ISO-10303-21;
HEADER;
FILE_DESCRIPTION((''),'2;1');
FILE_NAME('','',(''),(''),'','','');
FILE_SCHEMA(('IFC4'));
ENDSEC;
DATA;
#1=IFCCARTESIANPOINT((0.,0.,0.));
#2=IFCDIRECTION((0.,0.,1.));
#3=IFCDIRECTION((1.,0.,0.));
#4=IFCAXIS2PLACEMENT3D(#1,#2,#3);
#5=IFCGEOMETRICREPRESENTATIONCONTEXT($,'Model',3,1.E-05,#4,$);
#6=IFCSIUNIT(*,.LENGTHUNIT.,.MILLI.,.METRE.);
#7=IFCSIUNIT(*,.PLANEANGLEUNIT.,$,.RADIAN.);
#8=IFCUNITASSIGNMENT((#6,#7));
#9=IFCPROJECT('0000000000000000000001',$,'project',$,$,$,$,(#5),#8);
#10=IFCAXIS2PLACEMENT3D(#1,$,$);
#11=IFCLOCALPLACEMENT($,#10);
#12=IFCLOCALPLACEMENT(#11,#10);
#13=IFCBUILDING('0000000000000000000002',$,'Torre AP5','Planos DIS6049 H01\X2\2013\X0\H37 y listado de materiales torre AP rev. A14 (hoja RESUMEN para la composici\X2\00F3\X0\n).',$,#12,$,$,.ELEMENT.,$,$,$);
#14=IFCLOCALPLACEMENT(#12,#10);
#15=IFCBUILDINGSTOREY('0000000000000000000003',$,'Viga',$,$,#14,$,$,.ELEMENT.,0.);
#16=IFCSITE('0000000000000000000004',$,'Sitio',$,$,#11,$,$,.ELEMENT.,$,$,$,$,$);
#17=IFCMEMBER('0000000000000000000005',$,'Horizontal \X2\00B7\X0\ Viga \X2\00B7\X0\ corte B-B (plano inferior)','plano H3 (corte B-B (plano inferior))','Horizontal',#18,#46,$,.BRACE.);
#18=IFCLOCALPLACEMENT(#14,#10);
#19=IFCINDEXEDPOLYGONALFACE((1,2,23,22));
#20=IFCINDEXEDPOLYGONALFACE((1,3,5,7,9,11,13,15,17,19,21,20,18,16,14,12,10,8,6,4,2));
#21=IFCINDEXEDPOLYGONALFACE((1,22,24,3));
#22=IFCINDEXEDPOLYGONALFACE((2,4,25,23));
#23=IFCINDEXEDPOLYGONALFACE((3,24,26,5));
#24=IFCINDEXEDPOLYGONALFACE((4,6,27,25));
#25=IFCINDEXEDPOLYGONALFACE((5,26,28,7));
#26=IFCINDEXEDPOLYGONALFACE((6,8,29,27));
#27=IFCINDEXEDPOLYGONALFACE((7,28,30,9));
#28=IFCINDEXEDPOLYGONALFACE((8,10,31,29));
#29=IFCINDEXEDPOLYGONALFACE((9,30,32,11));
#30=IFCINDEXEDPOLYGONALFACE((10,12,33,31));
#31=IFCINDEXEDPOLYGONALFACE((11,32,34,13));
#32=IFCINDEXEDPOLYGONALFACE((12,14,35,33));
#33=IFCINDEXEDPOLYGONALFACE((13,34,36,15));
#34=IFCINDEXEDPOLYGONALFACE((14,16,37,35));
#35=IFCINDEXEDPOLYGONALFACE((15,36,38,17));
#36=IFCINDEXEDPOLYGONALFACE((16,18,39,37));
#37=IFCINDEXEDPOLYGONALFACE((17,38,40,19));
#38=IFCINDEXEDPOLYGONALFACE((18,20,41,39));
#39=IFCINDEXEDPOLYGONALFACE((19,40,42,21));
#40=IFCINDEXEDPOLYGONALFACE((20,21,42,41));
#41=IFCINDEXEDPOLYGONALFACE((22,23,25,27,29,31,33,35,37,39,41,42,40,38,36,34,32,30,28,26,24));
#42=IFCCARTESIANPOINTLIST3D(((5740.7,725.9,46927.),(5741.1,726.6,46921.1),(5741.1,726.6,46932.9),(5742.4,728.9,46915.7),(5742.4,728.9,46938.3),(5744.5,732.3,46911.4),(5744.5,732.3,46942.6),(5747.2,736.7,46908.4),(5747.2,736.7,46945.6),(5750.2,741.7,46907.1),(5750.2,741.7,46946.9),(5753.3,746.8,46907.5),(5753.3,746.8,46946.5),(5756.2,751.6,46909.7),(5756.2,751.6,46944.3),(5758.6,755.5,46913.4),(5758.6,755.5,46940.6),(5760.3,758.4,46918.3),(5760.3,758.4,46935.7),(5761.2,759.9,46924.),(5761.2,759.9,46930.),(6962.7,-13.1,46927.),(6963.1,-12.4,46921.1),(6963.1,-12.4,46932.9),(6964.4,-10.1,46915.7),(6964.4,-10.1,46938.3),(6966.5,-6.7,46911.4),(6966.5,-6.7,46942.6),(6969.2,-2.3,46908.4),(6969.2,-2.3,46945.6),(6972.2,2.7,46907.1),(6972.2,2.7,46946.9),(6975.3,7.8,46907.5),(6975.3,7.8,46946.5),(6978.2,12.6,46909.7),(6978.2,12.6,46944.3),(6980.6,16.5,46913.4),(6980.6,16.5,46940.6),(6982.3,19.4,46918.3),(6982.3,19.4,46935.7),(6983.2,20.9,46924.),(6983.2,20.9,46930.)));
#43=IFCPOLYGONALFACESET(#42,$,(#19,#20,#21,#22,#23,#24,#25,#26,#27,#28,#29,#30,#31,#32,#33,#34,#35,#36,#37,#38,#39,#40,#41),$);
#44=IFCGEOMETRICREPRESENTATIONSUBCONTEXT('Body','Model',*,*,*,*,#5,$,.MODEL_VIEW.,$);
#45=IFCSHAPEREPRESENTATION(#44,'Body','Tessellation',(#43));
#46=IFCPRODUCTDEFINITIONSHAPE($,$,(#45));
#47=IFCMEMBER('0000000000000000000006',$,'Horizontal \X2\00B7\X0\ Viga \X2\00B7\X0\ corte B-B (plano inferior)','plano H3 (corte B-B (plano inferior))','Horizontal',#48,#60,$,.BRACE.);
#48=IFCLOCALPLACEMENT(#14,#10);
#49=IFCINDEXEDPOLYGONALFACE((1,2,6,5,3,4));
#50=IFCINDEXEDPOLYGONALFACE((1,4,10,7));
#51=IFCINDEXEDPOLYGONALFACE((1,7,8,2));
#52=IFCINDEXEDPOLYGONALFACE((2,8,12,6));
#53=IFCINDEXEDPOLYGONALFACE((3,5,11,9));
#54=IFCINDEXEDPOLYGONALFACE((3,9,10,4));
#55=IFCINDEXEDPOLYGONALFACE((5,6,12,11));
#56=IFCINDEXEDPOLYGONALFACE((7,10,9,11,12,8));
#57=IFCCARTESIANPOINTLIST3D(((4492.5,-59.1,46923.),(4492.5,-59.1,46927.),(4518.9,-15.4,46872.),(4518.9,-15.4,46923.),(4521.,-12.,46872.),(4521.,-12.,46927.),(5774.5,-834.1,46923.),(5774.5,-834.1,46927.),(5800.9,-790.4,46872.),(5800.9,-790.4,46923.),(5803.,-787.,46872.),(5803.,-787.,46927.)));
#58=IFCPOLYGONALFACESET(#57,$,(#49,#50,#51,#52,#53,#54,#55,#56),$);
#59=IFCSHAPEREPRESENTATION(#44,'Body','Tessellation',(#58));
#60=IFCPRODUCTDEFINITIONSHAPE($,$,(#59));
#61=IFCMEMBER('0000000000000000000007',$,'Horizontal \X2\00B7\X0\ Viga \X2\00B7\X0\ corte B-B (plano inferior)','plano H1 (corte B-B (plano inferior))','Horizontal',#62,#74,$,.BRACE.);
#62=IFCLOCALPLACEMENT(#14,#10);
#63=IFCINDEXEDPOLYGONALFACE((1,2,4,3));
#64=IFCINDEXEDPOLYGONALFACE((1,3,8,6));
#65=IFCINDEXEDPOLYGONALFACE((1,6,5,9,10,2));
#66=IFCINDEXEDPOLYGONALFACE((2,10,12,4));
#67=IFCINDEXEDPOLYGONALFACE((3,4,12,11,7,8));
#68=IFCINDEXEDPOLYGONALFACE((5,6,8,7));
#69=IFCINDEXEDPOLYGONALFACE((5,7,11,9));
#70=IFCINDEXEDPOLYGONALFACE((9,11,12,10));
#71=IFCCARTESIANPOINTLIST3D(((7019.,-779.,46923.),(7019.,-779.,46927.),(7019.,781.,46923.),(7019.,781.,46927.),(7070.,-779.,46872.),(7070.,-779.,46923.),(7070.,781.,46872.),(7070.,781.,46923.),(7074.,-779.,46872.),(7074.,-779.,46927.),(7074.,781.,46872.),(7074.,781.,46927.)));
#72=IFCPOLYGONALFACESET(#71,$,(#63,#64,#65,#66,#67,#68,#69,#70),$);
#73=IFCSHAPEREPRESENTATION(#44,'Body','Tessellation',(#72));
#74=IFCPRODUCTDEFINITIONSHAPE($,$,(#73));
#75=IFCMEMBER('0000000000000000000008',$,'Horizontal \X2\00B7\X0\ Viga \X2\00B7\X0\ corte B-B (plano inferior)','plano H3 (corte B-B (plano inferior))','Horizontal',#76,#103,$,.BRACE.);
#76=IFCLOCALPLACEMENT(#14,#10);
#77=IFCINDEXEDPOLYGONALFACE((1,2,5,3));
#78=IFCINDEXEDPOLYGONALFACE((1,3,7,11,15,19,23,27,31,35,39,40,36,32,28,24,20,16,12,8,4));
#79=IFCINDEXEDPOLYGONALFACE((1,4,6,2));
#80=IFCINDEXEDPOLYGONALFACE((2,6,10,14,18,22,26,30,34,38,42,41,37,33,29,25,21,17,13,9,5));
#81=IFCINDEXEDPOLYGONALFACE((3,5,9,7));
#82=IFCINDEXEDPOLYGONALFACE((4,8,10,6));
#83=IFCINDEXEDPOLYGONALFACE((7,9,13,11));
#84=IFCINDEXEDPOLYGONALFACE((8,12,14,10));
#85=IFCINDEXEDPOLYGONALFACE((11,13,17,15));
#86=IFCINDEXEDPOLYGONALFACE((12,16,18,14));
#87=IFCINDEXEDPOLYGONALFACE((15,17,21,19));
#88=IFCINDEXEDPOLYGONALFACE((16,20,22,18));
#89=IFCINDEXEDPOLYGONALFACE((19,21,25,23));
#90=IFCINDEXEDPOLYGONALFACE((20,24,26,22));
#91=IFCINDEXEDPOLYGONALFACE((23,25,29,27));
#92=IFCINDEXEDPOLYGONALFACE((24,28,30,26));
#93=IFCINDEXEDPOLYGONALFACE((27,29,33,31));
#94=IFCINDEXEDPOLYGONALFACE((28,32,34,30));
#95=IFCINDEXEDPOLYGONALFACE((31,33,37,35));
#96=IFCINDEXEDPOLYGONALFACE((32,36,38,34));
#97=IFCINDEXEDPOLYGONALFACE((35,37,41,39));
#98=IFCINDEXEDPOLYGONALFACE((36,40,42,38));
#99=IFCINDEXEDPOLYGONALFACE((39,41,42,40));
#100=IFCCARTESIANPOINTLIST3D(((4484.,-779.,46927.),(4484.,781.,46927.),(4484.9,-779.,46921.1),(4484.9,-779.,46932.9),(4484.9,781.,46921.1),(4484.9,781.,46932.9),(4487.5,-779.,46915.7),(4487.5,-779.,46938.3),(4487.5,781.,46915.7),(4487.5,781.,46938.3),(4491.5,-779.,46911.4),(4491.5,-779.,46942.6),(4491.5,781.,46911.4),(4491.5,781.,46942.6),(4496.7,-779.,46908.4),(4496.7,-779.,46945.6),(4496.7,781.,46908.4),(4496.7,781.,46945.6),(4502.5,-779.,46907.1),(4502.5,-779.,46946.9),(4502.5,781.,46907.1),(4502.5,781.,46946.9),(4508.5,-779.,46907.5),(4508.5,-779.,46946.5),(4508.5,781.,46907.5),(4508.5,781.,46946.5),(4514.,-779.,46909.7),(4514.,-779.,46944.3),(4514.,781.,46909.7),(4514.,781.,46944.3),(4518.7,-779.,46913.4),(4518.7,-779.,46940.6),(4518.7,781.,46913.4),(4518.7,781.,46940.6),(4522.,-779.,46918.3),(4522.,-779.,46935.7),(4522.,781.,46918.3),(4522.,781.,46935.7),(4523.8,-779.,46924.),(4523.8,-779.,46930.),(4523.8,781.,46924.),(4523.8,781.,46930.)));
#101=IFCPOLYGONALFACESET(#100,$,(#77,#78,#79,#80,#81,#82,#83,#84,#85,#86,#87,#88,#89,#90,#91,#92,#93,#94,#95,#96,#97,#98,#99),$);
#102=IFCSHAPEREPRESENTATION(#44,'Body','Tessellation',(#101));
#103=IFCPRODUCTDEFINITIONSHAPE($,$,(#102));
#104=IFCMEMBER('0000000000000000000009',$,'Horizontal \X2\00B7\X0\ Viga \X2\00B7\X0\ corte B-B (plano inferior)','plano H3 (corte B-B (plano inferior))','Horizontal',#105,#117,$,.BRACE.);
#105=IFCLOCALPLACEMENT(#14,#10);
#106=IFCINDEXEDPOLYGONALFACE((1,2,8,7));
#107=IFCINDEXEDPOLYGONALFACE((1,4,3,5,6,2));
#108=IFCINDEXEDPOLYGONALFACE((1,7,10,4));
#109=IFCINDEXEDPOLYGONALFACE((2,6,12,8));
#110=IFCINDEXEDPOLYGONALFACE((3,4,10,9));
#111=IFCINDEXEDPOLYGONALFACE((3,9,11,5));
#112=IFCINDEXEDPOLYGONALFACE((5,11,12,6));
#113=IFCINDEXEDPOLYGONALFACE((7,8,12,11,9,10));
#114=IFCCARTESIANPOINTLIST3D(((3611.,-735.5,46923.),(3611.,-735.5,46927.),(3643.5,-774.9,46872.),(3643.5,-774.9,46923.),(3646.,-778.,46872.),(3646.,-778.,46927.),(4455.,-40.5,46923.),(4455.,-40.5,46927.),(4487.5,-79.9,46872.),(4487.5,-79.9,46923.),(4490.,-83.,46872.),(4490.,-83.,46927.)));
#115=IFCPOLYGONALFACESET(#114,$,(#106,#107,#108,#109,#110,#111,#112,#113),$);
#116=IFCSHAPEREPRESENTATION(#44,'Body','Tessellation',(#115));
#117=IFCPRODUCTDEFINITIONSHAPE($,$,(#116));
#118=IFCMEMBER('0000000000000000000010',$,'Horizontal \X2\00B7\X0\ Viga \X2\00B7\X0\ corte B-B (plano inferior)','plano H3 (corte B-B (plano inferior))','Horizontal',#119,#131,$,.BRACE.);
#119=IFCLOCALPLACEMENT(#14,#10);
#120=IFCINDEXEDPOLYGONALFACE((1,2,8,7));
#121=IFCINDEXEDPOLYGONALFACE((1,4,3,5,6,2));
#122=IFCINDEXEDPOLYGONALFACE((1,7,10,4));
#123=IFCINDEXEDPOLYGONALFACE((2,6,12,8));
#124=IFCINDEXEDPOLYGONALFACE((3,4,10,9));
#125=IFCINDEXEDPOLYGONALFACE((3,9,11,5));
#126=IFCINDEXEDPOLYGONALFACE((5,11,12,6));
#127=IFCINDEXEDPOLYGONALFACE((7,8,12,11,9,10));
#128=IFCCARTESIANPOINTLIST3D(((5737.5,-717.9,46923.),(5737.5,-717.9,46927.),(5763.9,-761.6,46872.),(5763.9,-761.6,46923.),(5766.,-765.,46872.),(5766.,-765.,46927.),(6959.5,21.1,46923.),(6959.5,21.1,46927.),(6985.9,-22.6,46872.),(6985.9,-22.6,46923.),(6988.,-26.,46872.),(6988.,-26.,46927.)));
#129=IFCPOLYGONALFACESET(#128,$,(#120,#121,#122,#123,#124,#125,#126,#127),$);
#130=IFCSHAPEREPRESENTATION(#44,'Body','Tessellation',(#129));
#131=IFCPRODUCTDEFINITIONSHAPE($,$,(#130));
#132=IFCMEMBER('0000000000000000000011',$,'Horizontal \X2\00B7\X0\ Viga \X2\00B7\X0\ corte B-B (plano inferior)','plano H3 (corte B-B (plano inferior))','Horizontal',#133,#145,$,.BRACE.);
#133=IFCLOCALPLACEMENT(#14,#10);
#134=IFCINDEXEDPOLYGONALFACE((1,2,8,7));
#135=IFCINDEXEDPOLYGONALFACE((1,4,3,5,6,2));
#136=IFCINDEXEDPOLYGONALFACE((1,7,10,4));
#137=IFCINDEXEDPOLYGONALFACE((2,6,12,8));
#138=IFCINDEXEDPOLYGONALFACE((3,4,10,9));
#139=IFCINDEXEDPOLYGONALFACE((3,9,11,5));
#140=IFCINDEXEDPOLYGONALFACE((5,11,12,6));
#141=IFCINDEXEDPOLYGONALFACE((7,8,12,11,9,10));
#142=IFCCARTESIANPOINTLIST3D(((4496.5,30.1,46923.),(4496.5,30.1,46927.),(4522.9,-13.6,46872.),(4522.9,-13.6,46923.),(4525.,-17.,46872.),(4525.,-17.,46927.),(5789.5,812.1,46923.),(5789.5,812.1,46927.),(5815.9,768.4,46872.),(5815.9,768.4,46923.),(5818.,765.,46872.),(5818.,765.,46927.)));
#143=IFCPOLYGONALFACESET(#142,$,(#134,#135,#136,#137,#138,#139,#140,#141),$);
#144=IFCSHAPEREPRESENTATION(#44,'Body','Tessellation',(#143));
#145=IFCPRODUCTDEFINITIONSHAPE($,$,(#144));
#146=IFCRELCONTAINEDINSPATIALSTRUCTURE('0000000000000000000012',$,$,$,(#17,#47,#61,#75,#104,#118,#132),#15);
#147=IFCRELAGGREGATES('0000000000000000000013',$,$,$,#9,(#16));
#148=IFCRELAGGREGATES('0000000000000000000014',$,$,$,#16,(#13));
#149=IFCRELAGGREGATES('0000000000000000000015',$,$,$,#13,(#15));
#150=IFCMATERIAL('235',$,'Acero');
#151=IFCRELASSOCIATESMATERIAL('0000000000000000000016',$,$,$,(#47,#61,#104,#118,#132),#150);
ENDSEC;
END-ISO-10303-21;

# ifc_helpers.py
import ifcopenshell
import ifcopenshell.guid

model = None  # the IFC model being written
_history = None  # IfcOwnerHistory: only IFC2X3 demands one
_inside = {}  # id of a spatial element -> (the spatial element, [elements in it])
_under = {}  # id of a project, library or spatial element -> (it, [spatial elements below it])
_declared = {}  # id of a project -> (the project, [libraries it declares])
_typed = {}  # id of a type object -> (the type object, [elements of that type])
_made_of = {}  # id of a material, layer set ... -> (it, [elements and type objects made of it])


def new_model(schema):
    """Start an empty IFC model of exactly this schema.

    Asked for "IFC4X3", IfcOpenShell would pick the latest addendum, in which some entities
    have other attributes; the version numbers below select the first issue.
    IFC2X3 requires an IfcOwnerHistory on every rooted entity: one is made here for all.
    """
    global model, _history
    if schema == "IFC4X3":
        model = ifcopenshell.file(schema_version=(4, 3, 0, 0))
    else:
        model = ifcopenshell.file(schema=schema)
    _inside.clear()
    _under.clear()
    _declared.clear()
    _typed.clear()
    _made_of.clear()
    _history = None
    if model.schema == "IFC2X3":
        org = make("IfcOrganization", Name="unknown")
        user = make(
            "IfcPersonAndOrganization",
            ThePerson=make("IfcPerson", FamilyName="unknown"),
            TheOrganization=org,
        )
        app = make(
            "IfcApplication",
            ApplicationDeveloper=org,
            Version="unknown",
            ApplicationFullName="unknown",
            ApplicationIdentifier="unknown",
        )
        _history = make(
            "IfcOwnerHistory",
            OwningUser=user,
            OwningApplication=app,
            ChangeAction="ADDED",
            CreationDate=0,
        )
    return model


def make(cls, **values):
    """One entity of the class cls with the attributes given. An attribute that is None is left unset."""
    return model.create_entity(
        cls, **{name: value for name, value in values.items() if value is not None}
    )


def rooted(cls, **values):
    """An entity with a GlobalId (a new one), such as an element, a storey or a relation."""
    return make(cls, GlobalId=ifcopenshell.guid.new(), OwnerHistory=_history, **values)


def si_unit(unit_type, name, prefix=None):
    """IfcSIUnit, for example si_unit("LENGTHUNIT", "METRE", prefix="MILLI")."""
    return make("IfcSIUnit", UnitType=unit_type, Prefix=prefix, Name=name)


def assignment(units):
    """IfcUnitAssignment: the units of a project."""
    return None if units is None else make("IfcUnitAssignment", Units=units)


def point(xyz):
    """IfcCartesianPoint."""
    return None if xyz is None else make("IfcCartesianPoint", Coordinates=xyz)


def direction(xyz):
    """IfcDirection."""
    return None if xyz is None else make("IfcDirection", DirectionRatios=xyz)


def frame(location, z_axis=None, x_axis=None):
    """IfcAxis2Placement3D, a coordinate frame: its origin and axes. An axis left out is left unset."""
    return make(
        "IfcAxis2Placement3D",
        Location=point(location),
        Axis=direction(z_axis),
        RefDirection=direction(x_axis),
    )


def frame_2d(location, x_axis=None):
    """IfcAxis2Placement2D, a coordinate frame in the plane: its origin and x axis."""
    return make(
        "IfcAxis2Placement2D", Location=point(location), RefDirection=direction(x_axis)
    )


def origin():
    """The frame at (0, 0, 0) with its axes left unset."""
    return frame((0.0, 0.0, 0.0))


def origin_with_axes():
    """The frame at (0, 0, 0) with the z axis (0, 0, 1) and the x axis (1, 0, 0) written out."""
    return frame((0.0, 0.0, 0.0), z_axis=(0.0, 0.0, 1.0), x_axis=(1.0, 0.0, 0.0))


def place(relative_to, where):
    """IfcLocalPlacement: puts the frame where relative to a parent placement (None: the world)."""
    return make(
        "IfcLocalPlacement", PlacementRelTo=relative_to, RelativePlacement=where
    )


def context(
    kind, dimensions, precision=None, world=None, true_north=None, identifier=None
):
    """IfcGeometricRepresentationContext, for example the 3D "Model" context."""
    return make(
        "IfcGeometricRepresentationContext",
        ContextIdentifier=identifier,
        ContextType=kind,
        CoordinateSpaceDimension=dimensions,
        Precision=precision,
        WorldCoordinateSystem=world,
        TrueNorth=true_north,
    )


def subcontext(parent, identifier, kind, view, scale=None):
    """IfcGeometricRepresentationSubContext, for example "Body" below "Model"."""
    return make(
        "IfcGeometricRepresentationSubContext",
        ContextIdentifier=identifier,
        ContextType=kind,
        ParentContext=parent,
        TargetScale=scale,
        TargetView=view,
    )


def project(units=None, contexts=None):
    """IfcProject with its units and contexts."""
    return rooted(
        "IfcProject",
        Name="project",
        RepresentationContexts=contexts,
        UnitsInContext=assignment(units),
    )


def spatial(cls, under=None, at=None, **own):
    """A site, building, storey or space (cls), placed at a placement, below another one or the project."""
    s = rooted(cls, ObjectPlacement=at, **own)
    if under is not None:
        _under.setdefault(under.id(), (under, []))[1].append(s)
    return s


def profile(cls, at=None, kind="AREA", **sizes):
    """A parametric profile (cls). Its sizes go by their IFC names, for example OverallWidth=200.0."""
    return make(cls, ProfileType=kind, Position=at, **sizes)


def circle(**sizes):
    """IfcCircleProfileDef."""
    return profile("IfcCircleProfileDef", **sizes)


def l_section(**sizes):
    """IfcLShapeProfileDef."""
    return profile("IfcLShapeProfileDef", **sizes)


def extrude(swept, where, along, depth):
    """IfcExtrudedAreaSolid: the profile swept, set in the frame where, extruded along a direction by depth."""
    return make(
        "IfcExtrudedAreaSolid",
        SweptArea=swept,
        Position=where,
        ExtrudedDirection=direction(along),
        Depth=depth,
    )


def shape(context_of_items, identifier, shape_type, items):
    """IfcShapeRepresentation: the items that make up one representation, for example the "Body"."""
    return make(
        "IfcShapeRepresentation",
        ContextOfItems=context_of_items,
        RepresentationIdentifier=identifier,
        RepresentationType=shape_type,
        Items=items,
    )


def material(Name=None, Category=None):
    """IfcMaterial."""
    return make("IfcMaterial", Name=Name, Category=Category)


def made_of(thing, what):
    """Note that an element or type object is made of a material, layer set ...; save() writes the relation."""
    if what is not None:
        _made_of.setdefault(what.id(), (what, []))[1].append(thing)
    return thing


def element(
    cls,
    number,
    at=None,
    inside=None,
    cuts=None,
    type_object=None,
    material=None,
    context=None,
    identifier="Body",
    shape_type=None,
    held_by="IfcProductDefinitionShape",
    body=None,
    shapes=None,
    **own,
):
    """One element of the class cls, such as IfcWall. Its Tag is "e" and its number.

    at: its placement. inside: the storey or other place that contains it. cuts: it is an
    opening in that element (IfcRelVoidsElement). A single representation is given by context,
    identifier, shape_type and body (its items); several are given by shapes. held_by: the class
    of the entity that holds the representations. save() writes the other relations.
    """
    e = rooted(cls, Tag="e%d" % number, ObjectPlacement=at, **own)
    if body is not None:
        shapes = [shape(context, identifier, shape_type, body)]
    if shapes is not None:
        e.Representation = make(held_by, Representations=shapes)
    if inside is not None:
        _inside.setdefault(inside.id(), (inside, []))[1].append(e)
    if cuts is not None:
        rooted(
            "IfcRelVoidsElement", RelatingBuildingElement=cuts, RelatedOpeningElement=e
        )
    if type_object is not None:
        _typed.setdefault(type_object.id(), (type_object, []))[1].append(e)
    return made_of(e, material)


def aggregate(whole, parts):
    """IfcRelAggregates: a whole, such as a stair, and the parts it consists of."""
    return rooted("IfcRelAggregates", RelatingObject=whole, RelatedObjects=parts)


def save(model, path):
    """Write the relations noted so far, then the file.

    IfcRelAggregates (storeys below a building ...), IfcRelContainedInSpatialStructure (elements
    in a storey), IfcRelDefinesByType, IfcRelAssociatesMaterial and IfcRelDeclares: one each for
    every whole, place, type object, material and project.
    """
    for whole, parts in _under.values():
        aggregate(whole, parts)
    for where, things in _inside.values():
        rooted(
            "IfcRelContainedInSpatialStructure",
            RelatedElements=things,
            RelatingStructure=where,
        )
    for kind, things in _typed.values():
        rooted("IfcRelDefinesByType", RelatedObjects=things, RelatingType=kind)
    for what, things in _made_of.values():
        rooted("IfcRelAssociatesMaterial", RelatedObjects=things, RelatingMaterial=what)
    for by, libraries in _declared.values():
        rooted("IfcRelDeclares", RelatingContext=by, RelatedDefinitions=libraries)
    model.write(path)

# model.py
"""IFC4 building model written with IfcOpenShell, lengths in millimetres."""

from ifc_helpers import new_model, si_unit, frame, frame_2d, origin, origin_with_axes, place, context, subcontext, project, spatial, circle, l_section, extrude, material, element, save


model = new_model("IFC4")

# Units and contexts
model_context = context("Model", 3, precision=1e-05, world=origin_with_axes())
body_context = subcontext(model_context, "Body", "Model", "MODEL_VIEW")
ifc_project = project(units=[si_unit("LENGTHUNIT", "METRE", prefix="MILLI"), si_unit("PLANEANGLEUNIT", "RADIAN")], contexts=[model_context])

# Site, building, storey
site_placement = place(None, origin())
site = spatial("IfcSite", under=ifc_project, at=site_placement, Name="Sitio", CompositionType="ELEMENT")
building_placement = place(site_placement, origin())
building = spatial("IfcBuilding", under=site, at=building_placement, Name="Torre AP5", Description="Planos DIS6049 H01–H37 y listado de materiales torre AP rev. A14 (hoja RESUMEN para la composición).", CompositionType="ELEMENT")
storey_placement = place(building_placement, origin())
storey = spatial("IfcBuildingStorey", under=building, at=storey_placement, Name="Viga", CompositionType="ELEMENT", Elevation=0.0)

# Members
ifc_material_1 = material(Name="235", Category="Acero")
member_1_placement = place(storey_placement, frame((5751.0, 743.0, 46927.0), z_axis=(0.855696, -0.517479, 0.0), x_axis=(-0.517479, -0.855696, 0.0)))
element("IfcMember", 1, at=member_1_placement, inside=storey, Name="Horizontal · Viga · corte B-B (plano inferior)", Description="plano H3 (corte B-B (plano inferior))", ObjectType="Horizontal", PredefinedType="BRACE", context=body_context, shape_type="SweptSolid", body=[
    extrude(circle(Radius=20.0), None, (0.0, 0.0, 1.0), 1428.1),
])
member_2_placement = place(storey_placement, frame((4521.0, -12.0, 46927.0), z_axis=(0.85578, -0.51734, 0.0), x_axis=(-0.51734, -0.85578, 0.0)))
element("IfcMember", 2, at=member_2_placement, inside=storey, material=ifc_material_1, Name="Horizontal · Viga · corte B-B (plano inferior)", Description="plano H3 (corte B-B (plano inferior))", ObjectType="Horizontal", PredefinedType="BRACE", context=body_context, shape_type="SweptSolid", body=[
    extrude(l_section(Depth=55.0, Width=55.0, Thickness=4.0, at=frame_2d((27.5, 27.5))), None, (0.0, 0.0, 1.0), 1498.0),
])
member_3_placement = place(storey_placement, frame((7074.0, 781.0, 46927.0), z_axis=(0.0, -1.0, 0.0), x_axis=(-1.0, 0.0, 0.0)))
element("IfcMember", 3, at=member_3_placement, inside=storey, material=ifc_material_1, Name="Horizontal · Viga · corte B-B (plano inferior)", Description="plano H1 (corte B-B (plano inferior))", ObjectType="Horizontal", PredefinedType="BRACE", context=body_context, shape_type="SweptSolid", body=[
    extrude(l_section(Depth=55.0, Width=55.0, Thickness=4.0, at=frame_2d((27.5, 27.5))), None, (0.0, 0.0, 1.0), 1560.0),
])
member_4_placement = place(storey_placement, frame((4504.0, 781.0, 46927.0), z_axis=(0.0, -1.0, 0.0), x_axis=(-1.0, 0.0, 0.0)))
element("IfcMember", 4, at=member_4_placement, inside=storey, Name="Horizontal · Viga · corte B-B (plano inferior)", Description="plano H3 (corte B-B (plano inferior))", ObjectType="Horizontal", PredefinedType="BRACE", context=body_context, shape_type="SweptSolid", body=[
    extrude(circle(Radius=20.0), None, (0.0, 0.0, 1.0), 1560.0),
])
member_5_placement = place(storey_placement, frame((4490.0, -83.0, 46927.0), z_axis=(-0.771957, -0.635675, 0.0), x_axis=(-0.635675, 0.771957, 0.0)))
element("IfcMember", 5, at=member_5_placement, inside=storey, material=ifc_material_1, Name="Horizontal · Viga · corte B-B (plano inferior)", Description="plano H3 (corte B-B (plano inferior))", ObjectType="Horizontal", PredefinedType="BRACE", context=body_context, shape_type="SweptSolid", body=[
    extrude(l_section(Depth=55.0, Width=55.0, Thickness=4.0, at=frame_2d((27.5, 27.5))), None, (0.0, 0.0, 1.0), 1093.3),
])
member_6_placement = place(storey_placement, frame((6988.0, -26.0, 46927.0), z_axis=(-0.855696, -0.517479, 0.0), x_axis=(-0.517479, 0.855696, 0.0)))
element("IfcMember", 6, at=member_6_placement, inside=storey, material=ifc_material_1, Name="Horizontal · Viga · corte B-B (plano inferior)", Description="plano H3 (corte B-B (plano inferior))", ObjectType="Horizontal", PredefinedType="BRACE", context=body_context, shape_type="SweptSolid", body=[
    extrude(l_section(Depth=55.0, Width=55.0, Thickness=4.0, at=frame_2d((27.5, 27.5))), None, (0.0, 0.0, 1.0), 1428.1),
])
member_7_placement = place(storey_placement, frame((5818.0, 765.0, 46927.0), z_axis=(-0.855677, -0.517509, 0.0), x_axis=(-0.517509, 0.855677, 0.0)))
element("IfcMember", 7, at=member_7_placement, inside=storey, material=ifc_material_1, Name="Horizontal · Viga · corte B-B (plano inferior)", Description="plano H3 (corte B-B (plano inferior))", ObjectType="Horizontal", PredefinedType="BRACE", context=body_context, shape_type="SweptSolid", body=[
    extrude(l_section(Depth=55.0, Width=55.0, Thickness=4.0, at=frame_2d((27.5, 27.5))), None, (0.0, 0.0, 1.0), 1511.1),
])

save(model, "model.ifc")
